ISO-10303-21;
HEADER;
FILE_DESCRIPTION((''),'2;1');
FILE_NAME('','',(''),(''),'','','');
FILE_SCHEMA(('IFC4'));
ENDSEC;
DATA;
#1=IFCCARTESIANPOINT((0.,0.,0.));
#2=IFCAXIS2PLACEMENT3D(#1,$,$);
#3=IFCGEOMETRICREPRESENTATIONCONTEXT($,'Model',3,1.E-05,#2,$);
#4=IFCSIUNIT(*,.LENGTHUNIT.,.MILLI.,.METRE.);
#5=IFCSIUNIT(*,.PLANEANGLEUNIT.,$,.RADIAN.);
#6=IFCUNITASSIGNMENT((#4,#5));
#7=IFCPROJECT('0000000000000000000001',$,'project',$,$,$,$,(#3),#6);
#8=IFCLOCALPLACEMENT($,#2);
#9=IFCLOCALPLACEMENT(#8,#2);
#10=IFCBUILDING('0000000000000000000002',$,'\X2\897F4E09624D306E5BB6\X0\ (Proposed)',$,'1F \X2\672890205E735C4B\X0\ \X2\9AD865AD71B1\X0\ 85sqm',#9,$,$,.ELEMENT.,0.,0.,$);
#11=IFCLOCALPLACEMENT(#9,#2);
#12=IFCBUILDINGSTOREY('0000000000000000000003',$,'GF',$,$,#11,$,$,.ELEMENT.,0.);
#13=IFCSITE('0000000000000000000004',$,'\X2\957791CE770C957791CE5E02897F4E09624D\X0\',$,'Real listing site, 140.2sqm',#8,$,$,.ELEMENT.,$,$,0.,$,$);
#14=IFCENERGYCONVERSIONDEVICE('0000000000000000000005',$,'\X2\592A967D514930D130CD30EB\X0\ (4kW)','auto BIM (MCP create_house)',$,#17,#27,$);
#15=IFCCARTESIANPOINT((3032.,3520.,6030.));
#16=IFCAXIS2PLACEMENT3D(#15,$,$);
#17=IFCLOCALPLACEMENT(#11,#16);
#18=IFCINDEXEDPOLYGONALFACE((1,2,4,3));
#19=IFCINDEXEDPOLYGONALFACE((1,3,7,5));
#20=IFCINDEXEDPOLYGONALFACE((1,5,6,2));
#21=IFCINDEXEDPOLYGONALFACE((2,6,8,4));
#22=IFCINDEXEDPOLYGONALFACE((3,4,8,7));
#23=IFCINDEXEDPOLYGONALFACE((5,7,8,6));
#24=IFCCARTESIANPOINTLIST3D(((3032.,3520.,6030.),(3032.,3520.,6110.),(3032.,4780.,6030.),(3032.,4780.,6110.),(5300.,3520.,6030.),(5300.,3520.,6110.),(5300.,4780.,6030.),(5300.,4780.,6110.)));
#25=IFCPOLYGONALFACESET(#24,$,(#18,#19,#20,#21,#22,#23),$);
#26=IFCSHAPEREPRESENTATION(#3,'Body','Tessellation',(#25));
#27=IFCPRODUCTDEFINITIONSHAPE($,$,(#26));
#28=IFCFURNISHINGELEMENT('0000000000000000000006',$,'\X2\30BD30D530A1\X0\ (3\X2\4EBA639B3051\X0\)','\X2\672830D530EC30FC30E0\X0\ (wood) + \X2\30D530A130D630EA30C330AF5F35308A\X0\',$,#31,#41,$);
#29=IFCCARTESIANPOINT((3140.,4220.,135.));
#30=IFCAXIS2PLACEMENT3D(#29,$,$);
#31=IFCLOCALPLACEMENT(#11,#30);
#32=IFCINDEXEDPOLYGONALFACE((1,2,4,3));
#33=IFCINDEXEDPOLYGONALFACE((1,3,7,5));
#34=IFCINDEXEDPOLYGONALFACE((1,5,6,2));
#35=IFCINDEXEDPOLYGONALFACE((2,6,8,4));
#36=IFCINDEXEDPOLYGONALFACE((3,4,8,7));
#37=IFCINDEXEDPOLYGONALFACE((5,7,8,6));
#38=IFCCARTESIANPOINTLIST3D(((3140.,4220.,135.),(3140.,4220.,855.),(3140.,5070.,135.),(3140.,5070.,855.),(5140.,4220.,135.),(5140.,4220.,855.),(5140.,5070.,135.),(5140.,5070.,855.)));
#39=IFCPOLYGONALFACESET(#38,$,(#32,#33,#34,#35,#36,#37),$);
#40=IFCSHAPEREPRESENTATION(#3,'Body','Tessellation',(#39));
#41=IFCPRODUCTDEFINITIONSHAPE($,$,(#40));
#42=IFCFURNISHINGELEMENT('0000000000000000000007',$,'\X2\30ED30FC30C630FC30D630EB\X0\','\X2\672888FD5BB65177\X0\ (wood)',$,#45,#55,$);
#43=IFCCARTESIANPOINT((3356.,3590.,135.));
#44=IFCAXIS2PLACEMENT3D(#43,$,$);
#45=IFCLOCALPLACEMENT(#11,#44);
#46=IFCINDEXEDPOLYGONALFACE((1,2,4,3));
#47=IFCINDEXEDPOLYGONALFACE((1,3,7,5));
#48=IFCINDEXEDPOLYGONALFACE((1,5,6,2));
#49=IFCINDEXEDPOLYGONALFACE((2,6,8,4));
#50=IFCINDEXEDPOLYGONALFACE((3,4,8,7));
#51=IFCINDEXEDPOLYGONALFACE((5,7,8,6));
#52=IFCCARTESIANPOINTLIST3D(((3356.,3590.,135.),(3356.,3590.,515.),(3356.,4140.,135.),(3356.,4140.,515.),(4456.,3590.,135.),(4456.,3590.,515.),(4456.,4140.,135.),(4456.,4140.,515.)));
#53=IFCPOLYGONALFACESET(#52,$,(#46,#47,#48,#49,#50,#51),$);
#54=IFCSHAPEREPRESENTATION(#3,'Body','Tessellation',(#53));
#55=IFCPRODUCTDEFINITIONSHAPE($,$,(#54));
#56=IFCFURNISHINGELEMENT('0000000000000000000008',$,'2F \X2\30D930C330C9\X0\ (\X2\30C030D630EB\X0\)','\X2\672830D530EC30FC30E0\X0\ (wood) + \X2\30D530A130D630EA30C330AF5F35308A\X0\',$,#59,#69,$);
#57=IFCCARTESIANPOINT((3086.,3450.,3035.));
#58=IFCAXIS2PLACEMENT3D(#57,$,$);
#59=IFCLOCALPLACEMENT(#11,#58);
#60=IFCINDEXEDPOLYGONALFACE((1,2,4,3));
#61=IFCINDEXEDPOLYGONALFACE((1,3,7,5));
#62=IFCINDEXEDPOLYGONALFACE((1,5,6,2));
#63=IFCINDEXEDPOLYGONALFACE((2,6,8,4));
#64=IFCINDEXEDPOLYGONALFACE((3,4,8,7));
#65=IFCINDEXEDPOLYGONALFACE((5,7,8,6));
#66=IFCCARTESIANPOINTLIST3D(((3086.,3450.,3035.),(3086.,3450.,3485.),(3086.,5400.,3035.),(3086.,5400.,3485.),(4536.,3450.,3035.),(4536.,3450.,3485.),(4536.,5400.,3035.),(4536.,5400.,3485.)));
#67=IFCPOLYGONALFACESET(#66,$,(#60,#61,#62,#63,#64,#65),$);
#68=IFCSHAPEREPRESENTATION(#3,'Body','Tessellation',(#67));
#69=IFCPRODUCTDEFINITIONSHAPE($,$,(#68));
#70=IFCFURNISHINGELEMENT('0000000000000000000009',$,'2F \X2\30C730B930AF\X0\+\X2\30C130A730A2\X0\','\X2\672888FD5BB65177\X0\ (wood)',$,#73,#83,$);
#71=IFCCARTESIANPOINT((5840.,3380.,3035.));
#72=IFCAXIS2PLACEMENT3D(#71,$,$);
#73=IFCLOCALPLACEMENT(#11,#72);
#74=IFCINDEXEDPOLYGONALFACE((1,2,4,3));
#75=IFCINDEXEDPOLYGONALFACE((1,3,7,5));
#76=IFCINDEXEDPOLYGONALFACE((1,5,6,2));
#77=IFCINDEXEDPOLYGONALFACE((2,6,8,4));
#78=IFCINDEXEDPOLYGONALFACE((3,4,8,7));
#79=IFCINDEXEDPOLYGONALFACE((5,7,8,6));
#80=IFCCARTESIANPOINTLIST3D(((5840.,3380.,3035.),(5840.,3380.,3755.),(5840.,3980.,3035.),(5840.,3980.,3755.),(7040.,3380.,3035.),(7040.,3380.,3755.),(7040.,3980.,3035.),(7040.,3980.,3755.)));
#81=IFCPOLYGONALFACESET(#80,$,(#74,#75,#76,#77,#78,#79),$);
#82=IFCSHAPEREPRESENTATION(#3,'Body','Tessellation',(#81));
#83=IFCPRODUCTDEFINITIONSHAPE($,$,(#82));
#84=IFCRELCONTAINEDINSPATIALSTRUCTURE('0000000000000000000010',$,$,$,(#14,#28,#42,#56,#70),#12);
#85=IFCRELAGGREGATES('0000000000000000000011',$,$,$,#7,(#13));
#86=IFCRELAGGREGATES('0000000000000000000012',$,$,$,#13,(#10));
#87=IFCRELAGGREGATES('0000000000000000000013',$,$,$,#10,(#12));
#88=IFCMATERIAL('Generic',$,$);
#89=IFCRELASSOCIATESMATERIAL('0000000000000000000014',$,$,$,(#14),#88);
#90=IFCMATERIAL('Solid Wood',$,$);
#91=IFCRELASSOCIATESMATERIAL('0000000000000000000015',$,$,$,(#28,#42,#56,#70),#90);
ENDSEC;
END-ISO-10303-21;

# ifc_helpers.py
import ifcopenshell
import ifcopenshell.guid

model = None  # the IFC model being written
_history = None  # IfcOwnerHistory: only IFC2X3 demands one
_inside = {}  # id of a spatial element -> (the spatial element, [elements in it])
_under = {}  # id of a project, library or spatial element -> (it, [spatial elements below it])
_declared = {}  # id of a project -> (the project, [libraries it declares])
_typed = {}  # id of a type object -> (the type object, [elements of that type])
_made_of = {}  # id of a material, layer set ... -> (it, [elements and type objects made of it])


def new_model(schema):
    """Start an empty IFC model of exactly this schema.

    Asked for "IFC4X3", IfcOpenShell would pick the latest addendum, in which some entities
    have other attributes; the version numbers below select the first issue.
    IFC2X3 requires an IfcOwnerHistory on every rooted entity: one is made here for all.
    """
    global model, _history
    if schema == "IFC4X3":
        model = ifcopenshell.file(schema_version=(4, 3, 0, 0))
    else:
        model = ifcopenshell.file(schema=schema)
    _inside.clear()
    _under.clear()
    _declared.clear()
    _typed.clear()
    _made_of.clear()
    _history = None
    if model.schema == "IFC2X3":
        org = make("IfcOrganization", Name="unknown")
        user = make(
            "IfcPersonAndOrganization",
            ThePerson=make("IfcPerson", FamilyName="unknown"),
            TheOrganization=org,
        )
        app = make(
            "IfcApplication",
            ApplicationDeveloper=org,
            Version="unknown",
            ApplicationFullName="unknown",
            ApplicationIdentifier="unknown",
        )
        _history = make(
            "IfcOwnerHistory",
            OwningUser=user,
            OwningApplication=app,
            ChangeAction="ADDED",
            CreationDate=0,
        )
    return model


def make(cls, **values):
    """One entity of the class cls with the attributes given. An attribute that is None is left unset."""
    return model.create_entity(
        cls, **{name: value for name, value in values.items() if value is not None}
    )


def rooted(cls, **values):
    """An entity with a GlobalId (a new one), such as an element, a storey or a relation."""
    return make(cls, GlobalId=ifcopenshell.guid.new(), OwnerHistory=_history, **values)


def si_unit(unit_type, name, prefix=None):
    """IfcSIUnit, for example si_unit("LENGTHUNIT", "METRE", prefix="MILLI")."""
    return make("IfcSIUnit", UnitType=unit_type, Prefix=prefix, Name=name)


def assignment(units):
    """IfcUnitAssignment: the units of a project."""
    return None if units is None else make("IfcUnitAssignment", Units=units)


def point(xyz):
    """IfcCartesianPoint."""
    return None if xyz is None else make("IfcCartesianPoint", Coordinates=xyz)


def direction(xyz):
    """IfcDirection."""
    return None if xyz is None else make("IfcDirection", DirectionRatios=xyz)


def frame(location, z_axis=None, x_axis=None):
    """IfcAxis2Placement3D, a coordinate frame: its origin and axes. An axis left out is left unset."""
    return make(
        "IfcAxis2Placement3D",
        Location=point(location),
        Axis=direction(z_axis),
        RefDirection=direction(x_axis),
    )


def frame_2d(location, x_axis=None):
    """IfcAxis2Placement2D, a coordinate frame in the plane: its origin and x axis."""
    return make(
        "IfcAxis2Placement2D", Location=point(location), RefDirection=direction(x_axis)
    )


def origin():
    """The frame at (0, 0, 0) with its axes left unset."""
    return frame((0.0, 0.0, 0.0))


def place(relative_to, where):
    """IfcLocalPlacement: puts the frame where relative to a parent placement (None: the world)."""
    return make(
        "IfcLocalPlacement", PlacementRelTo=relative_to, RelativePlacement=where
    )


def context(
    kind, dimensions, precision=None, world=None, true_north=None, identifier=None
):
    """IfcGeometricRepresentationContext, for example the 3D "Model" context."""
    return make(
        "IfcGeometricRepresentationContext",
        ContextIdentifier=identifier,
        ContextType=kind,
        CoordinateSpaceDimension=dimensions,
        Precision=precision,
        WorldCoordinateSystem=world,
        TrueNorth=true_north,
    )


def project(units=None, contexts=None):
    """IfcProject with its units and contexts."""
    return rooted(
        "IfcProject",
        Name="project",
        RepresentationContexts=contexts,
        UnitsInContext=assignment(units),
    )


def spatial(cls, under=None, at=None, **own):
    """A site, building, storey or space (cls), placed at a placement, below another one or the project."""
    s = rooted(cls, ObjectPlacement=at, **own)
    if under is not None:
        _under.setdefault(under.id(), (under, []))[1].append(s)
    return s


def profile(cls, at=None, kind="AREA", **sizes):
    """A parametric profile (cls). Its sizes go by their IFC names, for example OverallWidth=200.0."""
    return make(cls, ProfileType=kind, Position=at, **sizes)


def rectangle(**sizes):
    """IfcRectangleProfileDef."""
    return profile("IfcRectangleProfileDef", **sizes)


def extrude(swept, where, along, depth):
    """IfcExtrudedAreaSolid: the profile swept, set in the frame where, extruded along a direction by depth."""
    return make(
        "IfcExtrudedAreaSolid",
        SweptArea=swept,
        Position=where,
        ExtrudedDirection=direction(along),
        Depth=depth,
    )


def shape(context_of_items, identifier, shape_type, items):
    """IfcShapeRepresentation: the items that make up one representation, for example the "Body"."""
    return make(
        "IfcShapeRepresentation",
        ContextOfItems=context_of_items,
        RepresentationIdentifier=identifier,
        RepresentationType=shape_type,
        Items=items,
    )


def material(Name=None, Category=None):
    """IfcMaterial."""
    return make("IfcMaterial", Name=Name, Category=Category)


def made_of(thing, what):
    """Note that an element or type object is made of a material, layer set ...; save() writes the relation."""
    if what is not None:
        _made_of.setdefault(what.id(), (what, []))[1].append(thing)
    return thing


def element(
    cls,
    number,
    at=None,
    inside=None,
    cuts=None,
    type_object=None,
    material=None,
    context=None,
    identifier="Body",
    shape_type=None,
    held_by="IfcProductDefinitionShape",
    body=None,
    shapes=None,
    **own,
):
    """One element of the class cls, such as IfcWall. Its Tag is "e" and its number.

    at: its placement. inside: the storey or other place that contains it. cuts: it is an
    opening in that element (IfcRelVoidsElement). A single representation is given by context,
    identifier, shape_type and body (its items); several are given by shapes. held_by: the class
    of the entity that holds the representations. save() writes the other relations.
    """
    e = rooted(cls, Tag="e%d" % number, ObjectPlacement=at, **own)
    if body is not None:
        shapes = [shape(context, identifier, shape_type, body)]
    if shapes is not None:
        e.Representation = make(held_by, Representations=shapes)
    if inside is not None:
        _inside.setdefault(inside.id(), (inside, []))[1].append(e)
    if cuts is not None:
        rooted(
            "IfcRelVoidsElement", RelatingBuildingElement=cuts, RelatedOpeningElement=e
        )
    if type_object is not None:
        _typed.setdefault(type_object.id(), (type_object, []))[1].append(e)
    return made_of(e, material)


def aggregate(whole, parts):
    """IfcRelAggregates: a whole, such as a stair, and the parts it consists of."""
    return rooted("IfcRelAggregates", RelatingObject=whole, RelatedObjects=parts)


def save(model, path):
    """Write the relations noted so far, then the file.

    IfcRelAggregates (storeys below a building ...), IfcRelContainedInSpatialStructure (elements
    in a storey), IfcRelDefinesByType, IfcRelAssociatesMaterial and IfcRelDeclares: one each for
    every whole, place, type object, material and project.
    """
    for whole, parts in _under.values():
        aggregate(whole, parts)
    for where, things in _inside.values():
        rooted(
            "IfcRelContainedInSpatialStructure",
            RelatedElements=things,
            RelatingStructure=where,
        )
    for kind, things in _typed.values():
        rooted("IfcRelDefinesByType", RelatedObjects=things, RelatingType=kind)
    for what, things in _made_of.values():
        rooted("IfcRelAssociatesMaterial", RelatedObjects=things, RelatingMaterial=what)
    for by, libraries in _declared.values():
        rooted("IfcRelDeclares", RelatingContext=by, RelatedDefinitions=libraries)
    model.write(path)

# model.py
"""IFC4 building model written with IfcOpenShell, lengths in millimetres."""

from ifc_helpers import new_model, si_unit, frame, frame_2d, origin, place, context, project, spatial, rectangle, extrude, material, element, save


model = new_model("IFC4")

# Units and contexts
model_context = context("Model", 3, precision=1e-05, world=origin())
ifc_project = project(units=[si_unit("LENGTHUNIT", "METRE", prefix="MILLI"), si_unit("PLANEANGLEUNIT", "RADIAN")], contexts=[model_context])

# Site, building, storey
site_placement = place(None, origin())
site = spatial("IfcSite", under=ifc_project, at=site_placement, Name="長野県長野市西三才", ObjectType="Real listing site, 140.2sqm", CompositionType="ELEMENT", RefElevation=0.0)
building_placement = place(site_placement, origin())
building = spatial("IfcBuilding", under=site, at=building_placement, Name="西三才の家 (Proposed)", ObjectType="1F 木造平屋 高断熱 85sqm", CompositionType="ELEMENT", ElevationOfRefHeight=0.0, ElevationOfTerrain=0.0)
storey_placement = place(building_placement, origin())
storey = spatial("IfcBuildingStorey", under=building, at=storey_placement, Name="GF", CompositionType="ELEMENT", Elevation=0.0)

# Shared definitions
ifc_material_1 = material(Name="Solid Wood")

# Shared definitions
ifc_material_2 = material(Name="Generic")

# Energy conversion device
energy_conversion_device_placement = place(storey_placement, frame((3032.0, 3520.0, 6030.0)))
element("IfcEnergyConversionDevice", 1, at=energy_conversion_device_placement, inside=storey, material=ifc_material_2, Name="太陽光パネル (4kW)", Description="auto BIM (MCP create_house)", context=model_context, shape_type="SweptSolid", body=[
    extrude(rectangle(XDim=2268.0, YDim=1260.0, at=frame_2d((1134.0, 630.0))), frame((3032.0, 3520.0, 6030.0)), (0.0, 0.0, 1.0), 80.0),
])

# Furnishing elements
furnishing_1_placement = place(storey_placement, frame((3140.0, 4220.0, 135.0)))
element("IfcFurnishingElement", 2, at=furnishing_1_placement, inside=storey, material=ifc_material_1, Name="ソファ (3人掛け)", Description="木フレーム (wood) + ファブリック張り", context=model_context, shape_type="SweptSolid", body=[
    extrude(rectangle(XDim=2000.0, YDim=850.0, at=frame_2d((1000.0, 425.0))), frame((3140.0, 4220.0, 135.0)), (0.0, 0.0, 1.0), 720.0),
])
furnishing_2_placement = place(storey_placement, frame((3356.0, 3590.0, 135.0)))
element("IfcFurnishingElement", 3, at=furnishing_2_placement, inside=storey, material=ifc_material_1, Name="ローテーブル", Description="木製家具 (wood)", context=model_context, shape_type="SweptSolid", body=[
    extrude(rectangle(XDim=1100.0, YDim=550.0, at=frame_2d((550.0, 275.0))), frame((3356.0, 3590.0, 135.0)), (0.0, 0.0, 1.0), 380.0),
])
furnishing_3_placement = place(storey_placement, frame((3086.0, 3450.0, 3035.0)))
element("IfcFurnishingElement", 4, at=furnishing_3_placement, inside=storey, material=ifc_material_1, Name="2F ベッド (ダブル)", Description="木フレーム (wood) + ファブリック張り", context=model_context, shape_type="SweptSolid", body=[
    extrude(rectangle(XDim=1450.0, YDim=1950.0, at=frame_2d((725.0, 975.0))), frame((3086.0, 3450.0, 3035.0)), (0.0, 0.0, 1.0), 450.0),
])
furnishing_4_placement = place(storey_placement, frame((5840.0, 3380.0, 3035.0)))
element("IfcFurnishingElement", 5, at=furnishing_4_placement, inside=storey, material=ifc_material_1, Name="2F デスク+チェア", Description="木製家具 (wood)", context=model_context, shape_type="SweptSolid", body=[
    extrude(rectangle(XDim=1200.0, YDim=600.0, at=frame_2d((600.0, 300.0))), frame((5840.0, 3380.0, 3035.0)), (0.0, 0.0, 1.0), 720.0),
])

save(model, "model.ifc")
